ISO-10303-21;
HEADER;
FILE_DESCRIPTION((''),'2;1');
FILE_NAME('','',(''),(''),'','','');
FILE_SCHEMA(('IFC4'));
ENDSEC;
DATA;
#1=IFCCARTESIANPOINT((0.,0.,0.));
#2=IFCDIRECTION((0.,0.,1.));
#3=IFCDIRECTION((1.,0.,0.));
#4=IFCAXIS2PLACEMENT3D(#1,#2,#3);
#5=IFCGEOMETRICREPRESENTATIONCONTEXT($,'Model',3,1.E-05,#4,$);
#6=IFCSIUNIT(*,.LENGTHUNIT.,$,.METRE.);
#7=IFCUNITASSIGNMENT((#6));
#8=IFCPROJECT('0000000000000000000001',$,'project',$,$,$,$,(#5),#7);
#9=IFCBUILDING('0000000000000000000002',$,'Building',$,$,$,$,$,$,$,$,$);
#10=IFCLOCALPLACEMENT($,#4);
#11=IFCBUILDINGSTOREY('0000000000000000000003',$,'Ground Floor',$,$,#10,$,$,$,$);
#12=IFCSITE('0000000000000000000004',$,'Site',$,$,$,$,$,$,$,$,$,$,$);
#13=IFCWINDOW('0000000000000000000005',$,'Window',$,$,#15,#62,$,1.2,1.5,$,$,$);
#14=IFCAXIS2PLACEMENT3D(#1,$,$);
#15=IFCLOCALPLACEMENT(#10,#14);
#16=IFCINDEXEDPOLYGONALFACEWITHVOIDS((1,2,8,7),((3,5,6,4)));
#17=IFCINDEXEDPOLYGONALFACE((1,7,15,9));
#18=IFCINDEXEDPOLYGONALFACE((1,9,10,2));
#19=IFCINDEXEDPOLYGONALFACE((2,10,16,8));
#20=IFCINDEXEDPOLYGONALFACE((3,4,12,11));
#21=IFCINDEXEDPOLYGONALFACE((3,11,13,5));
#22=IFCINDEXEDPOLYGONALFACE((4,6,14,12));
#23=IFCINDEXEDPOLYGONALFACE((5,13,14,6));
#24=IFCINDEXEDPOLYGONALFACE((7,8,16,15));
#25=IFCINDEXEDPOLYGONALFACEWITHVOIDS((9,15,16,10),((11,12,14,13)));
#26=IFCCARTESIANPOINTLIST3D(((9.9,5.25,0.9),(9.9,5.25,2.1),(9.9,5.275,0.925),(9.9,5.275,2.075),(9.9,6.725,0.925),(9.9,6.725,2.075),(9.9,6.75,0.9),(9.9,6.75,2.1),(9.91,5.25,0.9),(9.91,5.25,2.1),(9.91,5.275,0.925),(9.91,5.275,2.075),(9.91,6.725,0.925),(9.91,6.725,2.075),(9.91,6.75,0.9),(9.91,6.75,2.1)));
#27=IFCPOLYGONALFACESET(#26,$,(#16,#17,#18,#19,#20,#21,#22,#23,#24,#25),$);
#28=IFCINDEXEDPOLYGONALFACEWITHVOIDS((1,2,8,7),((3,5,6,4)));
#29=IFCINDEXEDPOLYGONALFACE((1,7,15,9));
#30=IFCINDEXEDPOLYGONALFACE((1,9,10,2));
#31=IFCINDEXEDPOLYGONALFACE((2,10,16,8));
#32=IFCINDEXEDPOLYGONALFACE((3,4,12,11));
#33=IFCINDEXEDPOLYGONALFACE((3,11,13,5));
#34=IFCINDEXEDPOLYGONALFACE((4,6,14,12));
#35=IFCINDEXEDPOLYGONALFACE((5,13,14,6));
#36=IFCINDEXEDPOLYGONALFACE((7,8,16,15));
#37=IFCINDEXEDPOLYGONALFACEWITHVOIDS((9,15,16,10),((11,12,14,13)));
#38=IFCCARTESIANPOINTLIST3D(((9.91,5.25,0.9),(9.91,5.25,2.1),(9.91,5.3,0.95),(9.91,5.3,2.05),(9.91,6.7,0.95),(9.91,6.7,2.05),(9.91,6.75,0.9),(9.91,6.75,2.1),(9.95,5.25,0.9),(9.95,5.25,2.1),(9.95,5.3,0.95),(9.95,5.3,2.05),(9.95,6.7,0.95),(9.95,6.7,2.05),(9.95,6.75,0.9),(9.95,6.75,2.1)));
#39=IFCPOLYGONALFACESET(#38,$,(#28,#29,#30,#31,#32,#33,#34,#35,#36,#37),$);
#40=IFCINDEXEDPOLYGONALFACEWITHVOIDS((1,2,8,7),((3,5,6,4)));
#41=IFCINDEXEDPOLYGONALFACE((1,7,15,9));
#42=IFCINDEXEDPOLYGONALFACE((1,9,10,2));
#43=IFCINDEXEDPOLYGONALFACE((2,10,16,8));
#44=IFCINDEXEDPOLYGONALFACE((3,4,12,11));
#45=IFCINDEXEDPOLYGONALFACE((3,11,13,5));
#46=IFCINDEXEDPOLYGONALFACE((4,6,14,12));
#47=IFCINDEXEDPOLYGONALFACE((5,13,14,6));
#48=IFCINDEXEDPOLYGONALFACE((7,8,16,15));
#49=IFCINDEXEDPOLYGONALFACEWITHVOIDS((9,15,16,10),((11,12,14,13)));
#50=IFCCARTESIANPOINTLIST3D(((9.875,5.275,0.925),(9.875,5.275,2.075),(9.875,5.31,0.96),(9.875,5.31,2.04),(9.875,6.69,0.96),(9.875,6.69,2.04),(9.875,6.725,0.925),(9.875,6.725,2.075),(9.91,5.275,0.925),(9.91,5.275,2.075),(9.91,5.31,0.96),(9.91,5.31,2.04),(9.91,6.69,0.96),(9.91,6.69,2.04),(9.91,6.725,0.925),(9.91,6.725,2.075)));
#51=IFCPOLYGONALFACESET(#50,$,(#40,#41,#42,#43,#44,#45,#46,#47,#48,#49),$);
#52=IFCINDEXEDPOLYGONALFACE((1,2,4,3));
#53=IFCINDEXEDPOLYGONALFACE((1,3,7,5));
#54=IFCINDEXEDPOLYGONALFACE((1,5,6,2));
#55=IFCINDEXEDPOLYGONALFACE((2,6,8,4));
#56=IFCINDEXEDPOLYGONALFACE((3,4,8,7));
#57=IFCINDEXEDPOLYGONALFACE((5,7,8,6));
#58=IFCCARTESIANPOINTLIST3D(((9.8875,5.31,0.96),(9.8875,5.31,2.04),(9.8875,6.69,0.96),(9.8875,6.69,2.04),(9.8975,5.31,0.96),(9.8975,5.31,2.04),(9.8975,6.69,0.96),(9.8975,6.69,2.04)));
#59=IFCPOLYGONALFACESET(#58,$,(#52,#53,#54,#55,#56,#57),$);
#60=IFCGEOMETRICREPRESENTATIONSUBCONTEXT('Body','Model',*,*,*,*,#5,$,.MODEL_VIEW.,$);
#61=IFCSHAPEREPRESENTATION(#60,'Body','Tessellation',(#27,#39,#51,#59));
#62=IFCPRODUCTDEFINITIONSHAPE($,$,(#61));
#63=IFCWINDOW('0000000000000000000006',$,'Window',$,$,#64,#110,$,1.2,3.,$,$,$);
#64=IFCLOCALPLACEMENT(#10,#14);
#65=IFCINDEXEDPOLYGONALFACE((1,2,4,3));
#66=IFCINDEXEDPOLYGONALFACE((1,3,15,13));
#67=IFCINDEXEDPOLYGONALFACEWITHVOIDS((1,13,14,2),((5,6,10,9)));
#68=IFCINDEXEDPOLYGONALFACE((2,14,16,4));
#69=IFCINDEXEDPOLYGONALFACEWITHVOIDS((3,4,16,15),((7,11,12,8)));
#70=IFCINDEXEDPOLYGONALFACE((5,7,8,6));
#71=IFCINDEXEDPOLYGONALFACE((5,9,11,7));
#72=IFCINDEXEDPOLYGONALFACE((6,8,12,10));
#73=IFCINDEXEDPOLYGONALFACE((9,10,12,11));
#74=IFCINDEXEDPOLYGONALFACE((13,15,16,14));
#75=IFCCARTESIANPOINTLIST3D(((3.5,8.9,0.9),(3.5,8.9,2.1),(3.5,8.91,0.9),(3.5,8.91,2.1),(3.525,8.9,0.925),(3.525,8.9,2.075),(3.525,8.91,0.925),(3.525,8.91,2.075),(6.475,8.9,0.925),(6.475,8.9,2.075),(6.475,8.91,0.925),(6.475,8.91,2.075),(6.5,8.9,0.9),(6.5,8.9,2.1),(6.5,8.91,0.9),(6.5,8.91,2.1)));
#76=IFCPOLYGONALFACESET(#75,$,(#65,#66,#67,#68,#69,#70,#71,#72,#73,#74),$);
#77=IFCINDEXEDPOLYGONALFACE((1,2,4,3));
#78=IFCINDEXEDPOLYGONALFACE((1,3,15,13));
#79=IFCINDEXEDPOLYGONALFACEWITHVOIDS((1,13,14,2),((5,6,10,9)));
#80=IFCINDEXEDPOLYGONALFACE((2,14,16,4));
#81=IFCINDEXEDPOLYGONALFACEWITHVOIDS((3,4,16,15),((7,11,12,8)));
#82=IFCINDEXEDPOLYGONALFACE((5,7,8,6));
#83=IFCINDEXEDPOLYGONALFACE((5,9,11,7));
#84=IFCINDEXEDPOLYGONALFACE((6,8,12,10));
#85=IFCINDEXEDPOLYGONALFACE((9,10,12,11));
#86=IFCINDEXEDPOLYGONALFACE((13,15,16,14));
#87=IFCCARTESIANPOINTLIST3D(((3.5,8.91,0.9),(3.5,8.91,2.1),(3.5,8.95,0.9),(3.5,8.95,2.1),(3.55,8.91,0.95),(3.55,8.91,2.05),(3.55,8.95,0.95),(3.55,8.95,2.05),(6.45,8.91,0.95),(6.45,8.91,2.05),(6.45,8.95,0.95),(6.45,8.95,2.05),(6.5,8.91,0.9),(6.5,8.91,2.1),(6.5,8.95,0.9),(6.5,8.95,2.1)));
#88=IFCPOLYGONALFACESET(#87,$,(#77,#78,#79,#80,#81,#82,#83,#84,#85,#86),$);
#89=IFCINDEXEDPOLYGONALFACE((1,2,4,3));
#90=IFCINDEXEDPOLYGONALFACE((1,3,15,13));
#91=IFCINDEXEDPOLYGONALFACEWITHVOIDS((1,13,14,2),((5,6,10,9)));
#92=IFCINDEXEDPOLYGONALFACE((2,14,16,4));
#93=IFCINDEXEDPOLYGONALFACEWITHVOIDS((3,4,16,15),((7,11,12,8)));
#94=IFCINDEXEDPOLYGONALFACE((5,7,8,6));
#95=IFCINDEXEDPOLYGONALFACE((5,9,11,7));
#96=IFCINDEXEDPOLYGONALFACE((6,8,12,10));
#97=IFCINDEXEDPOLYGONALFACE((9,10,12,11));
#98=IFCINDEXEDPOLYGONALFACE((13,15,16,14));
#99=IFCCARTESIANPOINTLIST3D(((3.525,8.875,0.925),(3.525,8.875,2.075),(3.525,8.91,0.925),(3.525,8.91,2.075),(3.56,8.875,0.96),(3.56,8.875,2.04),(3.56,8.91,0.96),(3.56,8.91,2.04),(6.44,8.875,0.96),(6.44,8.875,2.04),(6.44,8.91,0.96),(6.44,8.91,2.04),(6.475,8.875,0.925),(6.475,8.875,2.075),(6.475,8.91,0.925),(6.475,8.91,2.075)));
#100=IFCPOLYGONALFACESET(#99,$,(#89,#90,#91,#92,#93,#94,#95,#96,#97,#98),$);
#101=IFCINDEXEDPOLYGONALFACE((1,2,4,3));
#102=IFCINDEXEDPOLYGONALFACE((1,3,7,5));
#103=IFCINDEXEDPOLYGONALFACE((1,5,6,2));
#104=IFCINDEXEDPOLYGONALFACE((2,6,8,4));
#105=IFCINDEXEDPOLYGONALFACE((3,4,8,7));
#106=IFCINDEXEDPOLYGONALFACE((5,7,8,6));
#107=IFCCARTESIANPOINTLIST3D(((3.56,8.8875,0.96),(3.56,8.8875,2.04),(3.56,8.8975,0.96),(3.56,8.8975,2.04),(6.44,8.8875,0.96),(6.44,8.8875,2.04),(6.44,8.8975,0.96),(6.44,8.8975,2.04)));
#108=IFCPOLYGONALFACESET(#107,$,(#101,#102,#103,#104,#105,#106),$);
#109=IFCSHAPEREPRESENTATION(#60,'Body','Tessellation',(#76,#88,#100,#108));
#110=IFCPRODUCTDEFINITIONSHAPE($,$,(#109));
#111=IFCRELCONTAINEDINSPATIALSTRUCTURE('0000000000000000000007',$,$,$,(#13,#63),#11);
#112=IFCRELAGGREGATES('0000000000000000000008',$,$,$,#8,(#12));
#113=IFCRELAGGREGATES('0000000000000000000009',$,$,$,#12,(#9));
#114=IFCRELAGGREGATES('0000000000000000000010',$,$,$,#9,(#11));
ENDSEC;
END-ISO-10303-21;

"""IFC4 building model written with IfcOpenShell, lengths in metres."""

from ifc_helpers import new_model, si_unit, frame, origin_with_axes, place, context, subcontext, project, spatial, line, indexed_curve, outline, extrude, element, save


model = new_model("IFC4")

# Units and contexts
model_context = context("Model", 3, precision=1e-05, world=origin_with_axes())
body_context = subcontext(model_context, "Body", "Model", "MODEL_VIEW")
ifc_project = project(units=[si_unit("LENGTHUNIT", "METRE")], contexts=[model_context])

# Site, building, storey
site = spatial("IfcSite", under=ifc_project, Name="Site")
building = spatial("IfcBuilding", under=site, Name="Building")
storey_placement = place(None, origin_with_axes())
storey = spatial("IfcBuildingStorey", under=building, at=storey_placement, Name="Ground Floor")

# Windows
for number, where, z_axis, x_axis, name in (
    (1, (10.0, 5.25, 0.9), (0.0, 0.0, 1.0), (0.0, 1.0, 0.0), "Window"),
):
    element("IfcWindow", number, at=place(storey_placement, frame(where, z_axis=z_axis, x_axis=x_axis)), inside=storey, Name=name, OverallHeight=1.2, OverallWidth=1.5, context=body_context, shape_type="SweptSolid", body=[
        extrude(outline(indexed_curve([(0.0, 0.0), (1.5, 0.0), (1.5, 1.2), (0.0, 1.2)], segments=[line(1, 2, 3, 4, 1)]), holes=[indexed_curve([(0.025, 0.025), (1.475, 0.025), (1.475, 1.175), (0.025, 1.175)], segments=[line(1, 2, 3, 4, 1)])]), frame((0.0, 0.09, 0.0), z_axis=(0.0, -1.0, 0.0), x_axis=(1.0, 0.0, 0.0)), (0.0, 0.0, -1.0), 0.01),
        extrude(outline(indexed_curve([(0.0, 0.0), (1.5, 0.0), (1.5, 1.2), (0.0, 1.2)], segments=[line(1, 2, 3, 4, 1)]), holes=[indexed_curve([(0.05, 0.05), (1.45, 0.05), (1.45, 1.15), (0.05, 1.15)], segments=[line(1, 2, 3, 4, 1)])]), frame((0.0, 0.05, 0.0), z_axis=(0.0, -1.0, 0.0), x_axis=(1.0, 0.0, 0.0)), (0.0, 0.0, -1.0), 0.04),
        extrude(outline(indexed_curve([(0.0, 0.0), (1.45, 0.0), (1.45, 1.15), (0.0, 1.15)], segments=[line(1, 2, 3, 4, 1)]), holes=[indexed_curve([(0.035, 0.035), (1.415, 0.035), (1.415, 1.115), (0.035, 1.115)], segments=[line(1, 2, 3, 4, 1)])]), frame((0.025, 0.09, 0.025), z_axis=(0.0, -1.0, 0.0), x_axis=(1.0, 0.0, 0.0)), (0.0, 0.0, -1.0), 0.035),
        extrude(outline(indexed_curve([(0.035, 0.035), (1.415, 0.035), (1.415, 1.115), (0.035, 1.115)], segments=[line(1, 2, 3, 4, 1)])), frame((0.025, 0.1025, 0.025), z_axis=(0.0, -1.0, 0.0), x_axis=(1.0, 0.0, 0.0)), (0.0, 0.0, -1.0), 0.01),
    ])
window_placement = place(storey_placement, frame((6.5, 9.0, 0.9), z_axis=(0.0, 0.0, 1.0), x_axis=(-1.0, 0.0, 0.0)))
element("IfcWindow", 2, at=window_placement, inside=storey, Name="Window", OverallHeight=1.2, OverallWidth=3.0, context=body_context, shape_type="SweptSolid", body=[
    extrude(outline(indexed_curve([(0.0, 0.0), (3.0, 0.0), (3.0, 1.2), (0.0, 1.2)], segments=[line(1, 2, 3, 4, 1)]), holes=[indexed_curve([(0.025, 0.025), (2.975, 0.025), (2.975, 1.175), (0.025, 1.175)], segments=[line(1, 2, 3, 4, 1)])]), frame((0.0, 0.09, 0.0), z_axis=(0.0, -1.0, 0.0), x_axis=(1.0, 0.0, 0.0)), (0.0, 0.0, -1.0), 0.01),
    extrude(outline(indexed_curve([(0.0, 0.0), (3.0, 0.0), (3.0, 1.2), (0.0, 1.2)], segments=[line(1, 2, 3, 4, 1)]), holes=[indexed_curve([(0.05, 0.05), (2.95, 0.05), (2.95, 1.15), (0.05, 1.15)], segments=[line(1, 2, 3, 4, 1)])]), frame((0.0, 0.05, 0.0), z_axis=(0.0, -1.0, 0.0), x_axis=(1.0, 0.0, 0.0)), (0.0, 0.0, -1.0), 0.04),
    extrude(outline(indexed_curve([(0.0, 0.0), (2.95, 0.0), (2.95, 1.15), (0.0, 1.15)], segments=[line(1, 2, 3, 4, 1)]), holes=[indexed_curve([(0.035, 0.035), (2.915, 0.035), (2.915, 1.115), (0.035, 1.115)], segments=[line(1, 2, 3, 4, 1)])]), frame((0.025, 0.09, 0.025), z_axis=(0.0, -1.0, 0.0), x_axis=(1.0, 0.0, 0.0)), (0.0, 0.0, -1.0), 0.035),
    extrude(outline(indexed_curve([(0.035, 0.035), (2.915, 0.035), (2.915, 1.115), (0.035, 1.115)], segments=[line(1, 2, 3, 4, 1)])), frame((0.025, 0.1025, 0.025), z_axis=(0.0, -1.0, 0.0), x_axis=(1.0, 0.0, 0.0)), (0.0, 0.0, -1.0), 0.01),
])

save(model, "model.ifc")
